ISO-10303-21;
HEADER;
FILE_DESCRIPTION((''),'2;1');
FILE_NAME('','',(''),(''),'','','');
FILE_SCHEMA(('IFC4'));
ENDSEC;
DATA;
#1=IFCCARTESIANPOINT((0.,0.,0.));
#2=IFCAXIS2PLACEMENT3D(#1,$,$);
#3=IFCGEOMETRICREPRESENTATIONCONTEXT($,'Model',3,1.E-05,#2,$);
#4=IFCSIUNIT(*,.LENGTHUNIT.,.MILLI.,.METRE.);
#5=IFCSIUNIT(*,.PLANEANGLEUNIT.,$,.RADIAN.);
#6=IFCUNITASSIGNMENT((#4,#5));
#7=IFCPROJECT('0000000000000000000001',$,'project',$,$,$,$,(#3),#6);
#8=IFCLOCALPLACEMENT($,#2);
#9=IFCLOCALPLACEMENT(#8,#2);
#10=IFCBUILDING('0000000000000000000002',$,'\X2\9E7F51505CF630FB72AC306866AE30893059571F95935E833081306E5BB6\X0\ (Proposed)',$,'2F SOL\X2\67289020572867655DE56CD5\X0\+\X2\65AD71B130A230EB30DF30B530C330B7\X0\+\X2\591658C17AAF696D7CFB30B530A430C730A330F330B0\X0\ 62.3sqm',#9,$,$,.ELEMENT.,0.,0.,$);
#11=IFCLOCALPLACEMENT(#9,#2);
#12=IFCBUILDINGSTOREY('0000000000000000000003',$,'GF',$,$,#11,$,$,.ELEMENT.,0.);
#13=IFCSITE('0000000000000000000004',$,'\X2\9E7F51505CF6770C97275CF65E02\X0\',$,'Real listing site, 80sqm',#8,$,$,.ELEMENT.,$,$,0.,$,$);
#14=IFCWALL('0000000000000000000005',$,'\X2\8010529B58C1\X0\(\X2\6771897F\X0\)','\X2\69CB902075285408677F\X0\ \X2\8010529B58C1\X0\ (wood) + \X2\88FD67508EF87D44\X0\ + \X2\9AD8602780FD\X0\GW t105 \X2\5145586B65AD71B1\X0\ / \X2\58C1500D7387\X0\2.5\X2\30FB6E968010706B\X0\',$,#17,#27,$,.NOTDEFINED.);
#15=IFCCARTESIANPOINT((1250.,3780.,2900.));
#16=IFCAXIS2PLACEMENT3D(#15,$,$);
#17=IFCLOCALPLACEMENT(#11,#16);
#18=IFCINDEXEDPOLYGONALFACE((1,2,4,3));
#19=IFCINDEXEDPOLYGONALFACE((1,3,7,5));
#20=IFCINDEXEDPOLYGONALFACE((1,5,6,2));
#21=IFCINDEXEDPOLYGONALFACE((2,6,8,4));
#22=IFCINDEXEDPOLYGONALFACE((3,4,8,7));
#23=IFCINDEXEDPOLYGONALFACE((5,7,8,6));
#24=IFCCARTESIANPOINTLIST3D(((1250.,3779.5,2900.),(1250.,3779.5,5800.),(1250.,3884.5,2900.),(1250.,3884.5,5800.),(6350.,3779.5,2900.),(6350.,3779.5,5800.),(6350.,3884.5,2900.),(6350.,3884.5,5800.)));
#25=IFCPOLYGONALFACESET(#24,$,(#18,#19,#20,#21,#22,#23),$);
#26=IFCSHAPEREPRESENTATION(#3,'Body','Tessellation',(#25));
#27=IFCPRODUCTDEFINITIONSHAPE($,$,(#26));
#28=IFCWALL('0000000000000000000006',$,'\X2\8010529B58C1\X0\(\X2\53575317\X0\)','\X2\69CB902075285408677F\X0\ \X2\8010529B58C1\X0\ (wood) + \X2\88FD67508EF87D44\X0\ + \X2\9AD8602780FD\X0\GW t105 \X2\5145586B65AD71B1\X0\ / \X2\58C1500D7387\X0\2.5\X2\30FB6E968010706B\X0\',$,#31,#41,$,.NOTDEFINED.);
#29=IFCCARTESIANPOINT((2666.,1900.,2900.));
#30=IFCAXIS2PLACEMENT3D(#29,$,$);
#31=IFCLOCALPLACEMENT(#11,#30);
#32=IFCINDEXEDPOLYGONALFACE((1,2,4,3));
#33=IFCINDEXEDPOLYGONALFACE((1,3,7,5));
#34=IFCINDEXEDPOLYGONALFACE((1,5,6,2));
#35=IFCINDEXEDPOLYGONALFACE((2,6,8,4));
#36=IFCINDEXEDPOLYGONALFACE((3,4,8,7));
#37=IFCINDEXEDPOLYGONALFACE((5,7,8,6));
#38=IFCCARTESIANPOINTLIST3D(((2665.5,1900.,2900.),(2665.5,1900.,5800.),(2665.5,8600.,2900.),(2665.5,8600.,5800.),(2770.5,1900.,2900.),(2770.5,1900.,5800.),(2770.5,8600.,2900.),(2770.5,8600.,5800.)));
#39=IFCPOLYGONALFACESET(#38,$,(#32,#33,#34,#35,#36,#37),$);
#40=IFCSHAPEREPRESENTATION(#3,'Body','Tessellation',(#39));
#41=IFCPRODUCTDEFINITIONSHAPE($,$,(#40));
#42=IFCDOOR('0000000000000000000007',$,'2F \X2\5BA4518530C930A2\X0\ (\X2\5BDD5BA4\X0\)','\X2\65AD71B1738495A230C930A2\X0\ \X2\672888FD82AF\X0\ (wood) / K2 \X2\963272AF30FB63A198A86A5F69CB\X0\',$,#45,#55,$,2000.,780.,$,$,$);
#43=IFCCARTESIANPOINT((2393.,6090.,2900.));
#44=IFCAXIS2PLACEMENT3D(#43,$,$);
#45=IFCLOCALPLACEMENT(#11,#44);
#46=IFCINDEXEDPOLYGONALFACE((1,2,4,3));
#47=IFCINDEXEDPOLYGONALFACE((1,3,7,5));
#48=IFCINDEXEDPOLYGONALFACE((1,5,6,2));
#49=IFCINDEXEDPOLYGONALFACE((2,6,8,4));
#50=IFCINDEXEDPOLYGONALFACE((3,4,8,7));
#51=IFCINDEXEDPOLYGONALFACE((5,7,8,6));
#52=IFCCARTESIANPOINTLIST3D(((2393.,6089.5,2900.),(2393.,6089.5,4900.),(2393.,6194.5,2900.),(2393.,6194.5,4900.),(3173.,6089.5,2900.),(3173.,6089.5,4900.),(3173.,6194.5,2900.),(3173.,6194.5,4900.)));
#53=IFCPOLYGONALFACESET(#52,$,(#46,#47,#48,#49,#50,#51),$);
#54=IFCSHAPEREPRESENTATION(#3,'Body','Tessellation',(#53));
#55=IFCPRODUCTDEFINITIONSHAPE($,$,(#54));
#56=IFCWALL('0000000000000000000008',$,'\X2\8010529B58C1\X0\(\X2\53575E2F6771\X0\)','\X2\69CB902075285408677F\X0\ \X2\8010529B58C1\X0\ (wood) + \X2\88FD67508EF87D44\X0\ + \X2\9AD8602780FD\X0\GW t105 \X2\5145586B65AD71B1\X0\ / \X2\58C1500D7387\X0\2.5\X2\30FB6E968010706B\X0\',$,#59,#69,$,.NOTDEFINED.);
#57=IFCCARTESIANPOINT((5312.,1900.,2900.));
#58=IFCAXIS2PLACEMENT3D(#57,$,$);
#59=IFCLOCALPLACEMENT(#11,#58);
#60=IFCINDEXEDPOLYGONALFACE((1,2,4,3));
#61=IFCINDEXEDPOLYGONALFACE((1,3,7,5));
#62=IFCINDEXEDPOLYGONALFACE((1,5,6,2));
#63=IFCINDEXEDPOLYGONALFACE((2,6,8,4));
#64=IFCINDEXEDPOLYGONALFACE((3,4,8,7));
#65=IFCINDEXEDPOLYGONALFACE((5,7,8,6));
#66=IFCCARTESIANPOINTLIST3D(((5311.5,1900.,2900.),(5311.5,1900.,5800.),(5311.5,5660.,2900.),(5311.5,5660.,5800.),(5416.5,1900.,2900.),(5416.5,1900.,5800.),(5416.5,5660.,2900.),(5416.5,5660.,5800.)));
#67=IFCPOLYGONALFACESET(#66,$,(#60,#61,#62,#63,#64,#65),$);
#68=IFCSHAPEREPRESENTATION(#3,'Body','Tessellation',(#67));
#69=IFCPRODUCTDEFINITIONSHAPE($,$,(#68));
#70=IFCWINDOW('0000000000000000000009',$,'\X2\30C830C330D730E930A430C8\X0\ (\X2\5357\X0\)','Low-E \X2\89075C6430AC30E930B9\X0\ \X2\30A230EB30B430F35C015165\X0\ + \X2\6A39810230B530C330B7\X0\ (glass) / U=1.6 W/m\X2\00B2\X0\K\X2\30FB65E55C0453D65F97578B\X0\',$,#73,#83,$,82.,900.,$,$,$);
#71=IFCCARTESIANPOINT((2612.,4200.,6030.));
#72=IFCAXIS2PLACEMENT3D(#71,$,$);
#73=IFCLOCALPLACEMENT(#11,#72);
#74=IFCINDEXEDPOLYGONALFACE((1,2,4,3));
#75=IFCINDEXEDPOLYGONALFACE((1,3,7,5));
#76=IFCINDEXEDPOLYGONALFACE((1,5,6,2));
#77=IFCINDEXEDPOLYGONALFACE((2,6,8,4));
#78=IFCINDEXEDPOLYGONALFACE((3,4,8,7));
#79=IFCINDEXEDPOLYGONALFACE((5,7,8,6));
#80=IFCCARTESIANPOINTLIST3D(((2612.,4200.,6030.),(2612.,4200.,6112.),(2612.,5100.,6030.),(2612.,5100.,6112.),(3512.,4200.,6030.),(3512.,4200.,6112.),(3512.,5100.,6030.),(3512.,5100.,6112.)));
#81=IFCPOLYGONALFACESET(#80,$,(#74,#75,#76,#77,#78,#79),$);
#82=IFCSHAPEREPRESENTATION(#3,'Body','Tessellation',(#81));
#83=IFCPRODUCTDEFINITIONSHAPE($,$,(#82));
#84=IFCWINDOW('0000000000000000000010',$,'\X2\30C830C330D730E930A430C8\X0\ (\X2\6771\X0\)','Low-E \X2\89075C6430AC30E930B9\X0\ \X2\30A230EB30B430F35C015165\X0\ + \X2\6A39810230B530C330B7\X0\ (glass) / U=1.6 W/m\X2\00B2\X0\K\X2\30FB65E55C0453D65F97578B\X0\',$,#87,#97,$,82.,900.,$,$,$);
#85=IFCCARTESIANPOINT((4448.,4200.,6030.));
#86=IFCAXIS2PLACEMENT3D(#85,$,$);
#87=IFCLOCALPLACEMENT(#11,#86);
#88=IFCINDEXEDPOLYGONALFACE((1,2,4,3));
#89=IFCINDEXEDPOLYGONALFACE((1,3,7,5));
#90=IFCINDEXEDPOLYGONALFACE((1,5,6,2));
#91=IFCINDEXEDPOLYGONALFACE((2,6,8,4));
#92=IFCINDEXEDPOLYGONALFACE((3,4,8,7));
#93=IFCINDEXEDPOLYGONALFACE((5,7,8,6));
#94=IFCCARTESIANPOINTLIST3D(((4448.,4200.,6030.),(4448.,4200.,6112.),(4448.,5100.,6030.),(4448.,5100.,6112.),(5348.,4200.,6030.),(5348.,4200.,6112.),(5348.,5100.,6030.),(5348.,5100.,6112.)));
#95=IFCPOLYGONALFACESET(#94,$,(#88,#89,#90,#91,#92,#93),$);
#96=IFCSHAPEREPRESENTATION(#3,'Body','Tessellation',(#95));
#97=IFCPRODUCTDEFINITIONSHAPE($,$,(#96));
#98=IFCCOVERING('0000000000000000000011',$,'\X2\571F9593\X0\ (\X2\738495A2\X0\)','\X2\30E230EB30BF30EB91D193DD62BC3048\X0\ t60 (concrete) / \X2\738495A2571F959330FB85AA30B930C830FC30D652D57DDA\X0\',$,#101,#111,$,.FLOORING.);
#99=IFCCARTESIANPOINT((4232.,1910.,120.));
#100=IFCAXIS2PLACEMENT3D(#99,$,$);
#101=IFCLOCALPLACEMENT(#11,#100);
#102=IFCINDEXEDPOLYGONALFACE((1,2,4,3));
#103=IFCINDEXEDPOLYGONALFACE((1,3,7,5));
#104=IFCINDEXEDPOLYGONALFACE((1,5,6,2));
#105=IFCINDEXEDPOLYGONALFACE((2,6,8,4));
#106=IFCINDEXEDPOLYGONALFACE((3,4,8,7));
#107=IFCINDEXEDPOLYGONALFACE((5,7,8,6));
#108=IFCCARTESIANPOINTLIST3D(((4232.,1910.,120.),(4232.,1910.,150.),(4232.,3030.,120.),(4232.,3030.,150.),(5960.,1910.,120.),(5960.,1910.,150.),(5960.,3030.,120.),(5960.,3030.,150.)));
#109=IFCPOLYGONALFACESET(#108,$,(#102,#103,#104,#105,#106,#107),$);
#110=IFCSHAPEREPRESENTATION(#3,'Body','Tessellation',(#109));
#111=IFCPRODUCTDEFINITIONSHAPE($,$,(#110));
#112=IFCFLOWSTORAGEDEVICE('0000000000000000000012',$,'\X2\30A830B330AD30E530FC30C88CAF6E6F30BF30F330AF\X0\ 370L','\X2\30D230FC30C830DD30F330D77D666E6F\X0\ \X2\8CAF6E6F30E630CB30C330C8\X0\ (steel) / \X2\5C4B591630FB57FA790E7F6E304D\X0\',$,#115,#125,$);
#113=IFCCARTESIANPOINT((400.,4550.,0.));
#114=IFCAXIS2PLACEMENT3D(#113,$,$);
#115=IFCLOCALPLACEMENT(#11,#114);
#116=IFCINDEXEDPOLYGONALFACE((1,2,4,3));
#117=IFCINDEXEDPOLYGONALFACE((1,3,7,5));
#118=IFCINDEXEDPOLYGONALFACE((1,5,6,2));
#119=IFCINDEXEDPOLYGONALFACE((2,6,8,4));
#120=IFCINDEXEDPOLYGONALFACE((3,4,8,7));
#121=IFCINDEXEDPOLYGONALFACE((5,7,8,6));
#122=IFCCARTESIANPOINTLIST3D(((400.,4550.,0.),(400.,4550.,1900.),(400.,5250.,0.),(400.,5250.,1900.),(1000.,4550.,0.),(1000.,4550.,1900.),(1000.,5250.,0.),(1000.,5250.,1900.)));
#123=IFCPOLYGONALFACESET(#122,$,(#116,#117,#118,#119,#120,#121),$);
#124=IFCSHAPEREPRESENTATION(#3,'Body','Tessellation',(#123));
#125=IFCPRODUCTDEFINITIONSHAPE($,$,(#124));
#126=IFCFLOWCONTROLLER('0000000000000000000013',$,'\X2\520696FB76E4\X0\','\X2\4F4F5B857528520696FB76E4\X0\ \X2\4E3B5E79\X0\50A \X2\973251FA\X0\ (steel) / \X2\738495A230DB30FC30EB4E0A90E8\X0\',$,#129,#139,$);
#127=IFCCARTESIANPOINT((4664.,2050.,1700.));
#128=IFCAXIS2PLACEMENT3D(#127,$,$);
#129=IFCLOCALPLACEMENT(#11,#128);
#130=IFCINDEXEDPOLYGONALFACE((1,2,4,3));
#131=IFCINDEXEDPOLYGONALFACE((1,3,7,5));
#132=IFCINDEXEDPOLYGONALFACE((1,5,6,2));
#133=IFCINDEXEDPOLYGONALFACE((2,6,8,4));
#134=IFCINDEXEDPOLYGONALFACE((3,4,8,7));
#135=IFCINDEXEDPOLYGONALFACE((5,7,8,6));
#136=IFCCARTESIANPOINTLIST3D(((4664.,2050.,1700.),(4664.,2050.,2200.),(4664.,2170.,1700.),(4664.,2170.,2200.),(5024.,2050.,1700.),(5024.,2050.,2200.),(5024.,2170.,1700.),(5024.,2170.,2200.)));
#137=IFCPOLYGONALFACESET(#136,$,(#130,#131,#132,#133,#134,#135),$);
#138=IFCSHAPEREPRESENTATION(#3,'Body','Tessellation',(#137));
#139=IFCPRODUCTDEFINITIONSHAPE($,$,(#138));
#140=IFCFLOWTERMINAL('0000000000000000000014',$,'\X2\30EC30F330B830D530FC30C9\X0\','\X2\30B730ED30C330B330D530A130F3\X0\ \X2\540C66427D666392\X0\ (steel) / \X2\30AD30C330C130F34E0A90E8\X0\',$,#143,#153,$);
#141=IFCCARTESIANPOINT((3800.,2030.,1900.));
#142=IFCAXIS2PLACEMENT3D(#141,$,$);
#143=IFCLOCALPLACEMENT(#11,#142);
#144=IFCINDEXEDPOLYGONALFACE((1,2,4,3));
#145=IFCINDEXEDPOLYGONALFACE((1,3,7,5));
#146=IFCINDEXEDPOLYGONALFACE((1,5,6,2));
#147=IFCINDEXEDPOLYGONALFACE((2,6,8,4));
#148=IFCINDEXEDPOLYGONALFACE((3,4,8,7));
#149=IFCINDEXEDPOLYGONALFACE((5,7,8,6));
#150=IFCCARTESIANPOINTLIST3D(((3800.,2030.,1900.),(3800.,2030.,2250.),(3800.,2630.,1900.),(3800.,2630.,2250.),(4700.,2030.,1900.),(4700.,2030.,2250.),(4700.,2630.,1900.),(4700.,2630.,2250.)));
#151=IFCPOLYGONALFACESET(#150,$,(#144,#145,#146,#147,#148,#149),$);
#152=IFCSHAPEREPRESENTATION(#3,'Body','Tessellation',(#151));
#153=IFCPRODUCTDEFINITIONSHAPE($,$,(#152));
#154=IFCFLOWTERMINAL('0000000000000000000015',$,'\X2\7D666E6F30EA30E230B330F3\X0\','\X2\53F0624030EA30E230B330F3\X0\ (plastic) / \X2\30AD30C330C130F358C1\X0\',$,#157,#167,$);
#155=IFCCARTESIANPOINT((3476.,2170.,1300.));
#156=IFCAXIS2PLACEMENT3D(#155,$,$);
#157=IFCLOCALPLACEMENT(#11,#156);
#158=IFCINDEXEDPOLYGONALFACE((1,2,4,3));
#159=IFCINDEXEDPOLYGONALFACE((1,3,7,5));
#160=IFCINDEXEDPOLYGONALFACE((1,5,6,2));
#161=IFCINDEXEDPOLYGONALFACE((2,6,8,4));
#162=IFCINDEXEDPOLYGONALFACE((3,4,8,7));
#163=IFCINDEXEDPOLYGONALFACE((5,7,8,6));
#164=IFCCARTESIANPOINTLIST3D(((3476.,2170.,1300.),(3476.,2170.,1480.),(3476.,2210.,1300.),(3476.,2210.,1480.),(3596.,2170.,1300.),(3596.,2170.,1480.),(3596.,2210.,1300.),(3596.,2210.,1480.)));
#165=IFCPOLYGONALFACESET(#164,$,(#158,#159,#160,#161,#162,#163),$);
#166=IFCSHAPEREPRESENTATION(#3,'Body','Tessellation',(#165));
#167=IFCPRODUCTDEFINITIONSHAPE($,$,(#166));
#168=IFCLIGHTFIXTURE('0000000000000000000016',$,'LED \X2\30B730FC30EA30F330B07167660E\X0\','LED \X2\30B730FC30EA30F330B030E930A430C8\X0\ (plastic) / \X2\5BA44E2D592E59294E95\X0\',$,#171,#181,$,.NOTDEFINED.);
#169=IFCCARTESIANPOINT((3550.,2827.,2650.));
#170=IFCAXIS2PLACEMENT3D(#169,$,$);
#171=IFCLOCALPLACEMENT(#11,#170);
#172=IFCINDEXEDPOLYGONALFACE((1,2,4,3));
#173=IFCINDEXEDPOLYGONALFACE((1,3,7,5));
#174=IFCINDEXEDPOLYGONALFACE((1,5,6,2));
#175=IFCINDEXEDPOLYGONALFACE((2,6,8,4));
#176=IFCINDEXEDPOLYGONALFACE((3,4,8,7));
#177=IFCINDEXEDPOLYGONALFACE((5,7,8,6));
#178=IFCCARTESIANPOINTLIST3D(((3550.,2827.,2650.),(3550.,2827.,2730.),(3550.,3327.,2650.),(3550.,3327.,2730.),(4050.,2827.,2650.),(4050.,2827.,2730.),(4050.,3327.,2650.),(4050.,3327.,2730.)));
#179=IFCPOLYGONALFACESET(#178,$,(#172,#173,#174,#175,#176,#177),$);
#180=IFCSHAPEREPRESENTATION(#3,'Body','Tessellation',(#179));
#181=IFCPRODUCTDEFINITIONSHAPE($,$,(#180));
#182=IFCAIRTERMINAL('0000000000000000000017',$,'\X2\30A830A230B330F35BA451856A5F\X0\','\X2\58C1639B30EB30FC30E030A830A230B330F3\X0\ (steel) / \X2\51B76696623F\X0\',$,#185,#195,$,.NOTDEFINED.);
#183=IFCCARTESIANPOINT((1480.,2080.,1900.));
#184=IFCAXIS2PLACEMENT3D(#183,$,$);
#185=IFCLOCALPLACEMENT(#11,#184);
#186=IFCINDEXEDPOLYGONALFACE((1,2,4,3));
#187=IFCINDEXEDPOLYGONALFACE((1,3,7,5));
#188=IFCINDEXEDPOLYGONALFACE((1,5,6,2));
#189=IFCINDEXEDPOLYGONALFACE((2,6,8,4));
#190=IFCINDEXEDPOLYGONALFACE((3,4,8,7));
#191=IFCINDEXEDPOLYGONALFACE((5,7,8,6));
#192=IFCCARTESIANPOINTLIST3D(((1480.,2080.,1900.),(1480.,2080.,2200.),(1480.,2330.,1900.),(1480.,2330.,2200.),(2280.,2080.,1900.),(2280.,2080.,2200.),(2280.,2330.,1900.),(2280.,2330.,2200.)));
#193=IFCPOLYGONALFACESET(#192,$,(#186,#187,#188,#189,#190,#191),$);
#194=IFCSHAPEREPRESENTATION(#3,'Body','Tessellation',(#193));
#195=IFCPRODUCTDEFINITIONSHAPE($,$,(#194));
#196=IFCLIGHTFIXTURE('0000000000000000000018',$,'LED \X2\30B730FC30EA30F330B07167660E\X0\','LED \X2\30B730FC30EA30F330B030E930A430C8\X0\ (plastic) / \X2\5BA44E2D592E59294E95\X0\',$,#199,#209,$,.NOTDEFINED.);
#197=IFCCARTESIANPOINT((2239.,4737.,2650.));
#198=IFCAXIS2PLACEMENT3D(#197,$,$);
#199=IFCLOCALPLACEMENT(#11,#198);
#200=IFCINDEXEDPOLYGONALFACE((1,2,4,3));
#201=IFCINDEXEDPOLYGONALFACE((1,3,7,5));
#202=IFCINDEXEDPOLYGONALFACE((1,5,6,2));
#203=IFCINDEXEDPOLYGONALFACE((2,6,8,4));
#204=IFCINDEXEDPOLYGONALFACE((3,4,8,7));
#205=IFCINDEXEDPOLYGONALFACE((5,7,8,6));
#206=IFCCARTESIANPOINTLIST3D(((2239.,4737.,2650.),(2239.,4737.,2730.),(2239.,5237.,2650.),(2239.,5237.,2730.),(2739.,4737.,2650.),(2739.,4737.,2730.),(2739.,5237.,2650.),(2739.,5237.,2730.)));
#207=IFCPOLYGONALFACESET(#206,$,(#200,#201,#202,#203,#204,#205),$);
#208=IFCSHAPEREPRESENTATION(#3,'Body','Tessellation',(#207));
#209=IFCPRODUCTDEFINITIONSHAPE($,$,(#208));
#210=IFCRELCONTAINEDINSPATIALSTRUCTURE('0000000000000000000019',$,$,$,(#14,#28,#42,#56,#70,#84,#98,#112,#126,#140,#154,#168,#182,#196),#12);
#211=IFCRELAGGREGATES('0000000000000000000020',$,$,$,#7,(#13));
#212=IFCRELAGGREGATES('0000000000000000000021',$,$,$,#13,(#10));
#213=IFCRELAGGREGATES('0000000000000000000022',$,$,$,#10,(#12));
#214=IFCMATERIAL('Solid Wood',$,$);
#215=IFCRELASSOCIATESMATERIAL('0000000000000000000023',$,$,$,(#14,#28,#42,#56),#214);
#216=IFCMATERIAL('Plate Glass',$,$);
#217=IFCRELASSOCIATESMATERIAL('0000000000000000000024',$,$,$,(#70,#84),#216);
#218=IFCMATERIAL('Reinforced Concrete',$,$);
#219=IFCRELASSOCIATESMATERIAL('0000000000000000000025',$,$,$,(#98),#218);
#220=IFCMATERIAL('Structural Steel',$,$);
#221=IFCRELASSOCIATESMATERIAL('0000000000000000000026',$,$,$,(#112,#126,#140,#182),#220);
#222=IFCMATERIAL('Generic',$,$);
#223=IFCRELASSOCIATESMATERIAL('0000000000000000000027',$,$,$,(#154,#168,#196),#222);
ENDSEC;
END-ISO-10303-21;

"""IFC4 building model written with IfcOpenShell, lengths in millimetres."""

from ifc_helpers import new_model, si_unit, frame, frame_2d, origin, place, context, project, spatial, rectangle, extrude, material, element, fill, save


model = new_model("IFC4")

# Units and contexts
model_context = context("Model", 3, precision=1e-05, world=origin())
ifc_project = project(units=[si_unit("LENGTHUNIT", "METRE", prefix="MILLI"), si_unit("PLANEANGLEUNIT", "RADIAN")], contexts=[model_context])

# Site, building, storey
site_placement = place(None, origin())
site = spatial("IfcSite", under=ifc_project, at=site_placement, Name="鹿児島県霧島市", ObjectType="Real listing site, 80sqm", CompositionType="ELEMENT", RefElevation=0.0)
building_placement = place(site_placement, origin())
building = spatial("IfcBuilding", under=site, at=building_placement, Name="鹿児島・犬と暮らす土間広めの家 (Proposed)", ObjectType="2F SOL木造在来工法+断熱アルミサッシ+外壁窯業系サイディング 62.3sqm", CompositionType="ELEMENT", ElevationOfRefHeight=0.0, ElevationOfTerrain=0.0)
storey_placement = place(building_placement, origin())
storey = spatial("IfcBuildingStorey", under=building, at=storey_placement, Name="GF", CompositionType="ELEMENT", Elevation=0.0)

# Shared definitions
ifc_material_1 = material(Name="Solid Wood")

# Wall
wall_1_placement = place(storey_placement, frame((1250.0, 3780.0, 2900.0)))
element("IfcWall", 1, at=wall_1_placement, inside=storey, material=ifc_material_1, Name="耐力壁(東西)", Description="構造用合板 耐力壁 (wood) + 製材軸組 + 高性能GW t105 充填断熱 / 壁倍率2.5・準耐火", PredefinedType="NOTDEFINED", context=model_context, shape_type="SweptSolid", body=[
    extrude(rectangle(XDim=5100.0, YDim=105.0, at=frame_2d((2550.0, 52.0))), frame((1250.0, 3780.0, 2900.0)), (0.0, 0.0, 1.0), 2900.0),
])

# Wall, opening, door
wall_2_placement = place(storey_placement, frame((2666.0, 1900.0, 2900.0)))
wall_2 = element("IfcWall", 2, at=wall_2_placement, inside=storey, material=ifc_material_1, Name="耐力壁(南北)", Description="構造用合板 耐力壁 (wood) + 製材軸組 + 高性能GW t105 充填断熱 / 壁倍率2.5・準耐火", PredefinedType="NOTDEFINED", context=model_context, shape_type="SweptSolid", body=[
    extrude(rectangle(XDim=105.0, YDim=6700.0, at=frame_2d((52.0, 3350.0))), frame((2666.0, 1900.0, 2900.0)), (0.0, 0.0, 1.0), 2900.0),
])
opening_placement = place(storey_placement, frame((2393.0, 6090.0, 2900.0)))
opening = element("IfcOpeningElement", 3, at=opening_placement, cuts=wall_2, PredefinedType="NOTDEFINED", context=model_context, shape_type="SweptSolid", body=[
    extrude(rectangle(XDim=780.0, YDim=105.0, at=frame_2d((390.0, 52.0))), frame((2393.0, 6090.0, 2900.0)), (0.0, 0.0, 1.0), 2000.0),
])
door_placement = place(storey_placement, frame((2393.0, 6090.0, 2900.0)))
door = element("IfcDoor", 4, at=door_placement, inside=storey, material=ifc_material_1, Name="2F 室内ドア (寝室)", Description="断熱玄関ドア 木製芯 (wood) / K2 防犯・採風機構", OverallHeight=2000.0, OverallWidth=780.0, context=model_context, shape_type="SweptSolid", body=[
    extrude(rectangle(XDim=780.0, YDim=105.0, at=frame_2d((390.0, 52.0))), frame((2393.0, 6090.0, 2900.0)), (0.0, 0.0, 1.0), 2000.0),
])
fill(opening, door)

# Wall
wall_3_placement = place(storey_placement, frame((5312.0, 1900.0, 2900.0)))
element("IfcWall", 5, at=wall_3_placement, inside=storey, material=ifc_material_1, Name="耐力壁(南帯東)", Description="構造用合板 耐力壁 (wood) + 製材軸組 + 高性能GW t105 充填断熱 / 壁倍率2.5・準耐火", PredefinedType="NOTDEFINED", context=model_context, shape_type="SweptSolid", body=[
    extrude(rectangle(XDim=105.0, YDim=3760.0, at=frame_2d((52.0, 1880.0))), frame((5312.0, 1900.0, 2900.0)), (0.0, 0.0, 1.0), 2900.0),
])

# Windows
ifc_material_2 = material(Name="Plate Glass")
window_1_placement = place(storey_placement, frame((2612.0, 4200.0, 6030.0)))
element("IfcWindow", 6, at=window_1_placement, inside=storey, material=ifc_material_2, Name="トップライト (南)", Description="Low-E 複層ガラス アルゴン封入 + 樹脂サッシ (glass) / U=1.6 W/m²K・日射取得型", OverallHeight=82.0, OverallWidth=900.0, context=model_context, shape_type="SweptSolid", body=[
    extrude(rectangle(XDim=900.0, YDim=900.0, at=frame_2d((450.0, 450.0))), frame((2612.0, 4200.0, 6030.0)), (0.0, 0.0, 1.0), 82.0),
])
window_2_placement = place(storey_placement, frame((4448.0, 4200.0, 6030.0)))
element("IfcWindow", 7, at=window_2_placement, inside=storey, material=ifc_material_2, Name="トップライト (東)", Description="Low-E 複層ガラス アルゴン封入 + 樹脂サッシ (glass) / U=1.6 W/m²K・日射取得型", OverallHeight=82.0, OverallWidth=900.0, context=model_context, shape_type="SweptSolid", body=[
    extrude(rectangle(XDim=900.0, YDim=900.0, at=frame_2d((450.0, 450.0))), frame((4448.0, 4200.0, 6030.0)), (0.0, 0.0, 1.0), 82.0),
])

# Covering
ifc_material_3 = material(Name="Reinforced Concrete")
covering_placement = place(storey_placement, frame((4232.0, 1910.0, 120.0)))
element("IfcCovering", 8, at=covering_placement, inside=storey, material=ifc_material_3, Name="土間 (玄関)", Description="モルタル金鏝押え t60 (concrete) / 玄関土間・薪ストーブ動線", PredefinedType="FLOORING", context=model_context, shape_type="SweptSolid", body=[
    extrude(rectangle(XDim=1728.0, YDim=1120.0, at=frame_2d((864.0, 560.0))), frame((4232.0, 1910.0, 120.0)), (0.0, 0.0, 1.0), 30.0),
])

# Flow storage device
ifc_material_4 = material(Name="Structural Steel")
flow_storage_device_placement = place(storey_placement, frame((400.0, 4550.0, 0.0)))
element("IfcFlowStorageDevice", 9, at=flow_storage_device_placement, inside=storey, material=ifc_material_4, Name="エコキュート貯湯タンク 370L", Description="ヒートポンプ給湯 貯湯ユニット (steel) / 屋外・基礎置き", context=model_context, shape_type="SweptSolid", body=[
    extrude(rectangle(XDim=600.0, YDim=700.0, at=frame_2d((300.0, 350.0))), frame((400.0, 4550.0, 0.0)), (0.0, 0.0, 1.0), 1900.0),
])

# Flow controller
flow_controller_placement = place(storey_placement, frame((4664.0, 2050.0, 1700.0)))
element("IfcFlowController", 10, at=flow_controller_placement, inside=storey, material=ifc_material_4, Name="分電盤", Description="住宅用分電盤 主幹50A 露出 (steel) / 玄関ホール上部", context=model_context, shape_type="SweptSolid", body=[
    extrude(rectangle(XDim=360.0, YDim=120.0, at=frame_2d((180.0, 60.0))), frame((4664.0, 2050.0, 1700.0)), (0.0, 0.0, 1.0), 500.0),
])

# Flow terminals
flow_terminal_1_placement = place(storey_placement, frame((3800.0, 2030.0, 1900.0)))
element("IfcFlowTerminal", 11, at=flow_terminal_1_placement, inside=storey, material=ifc_material_4, Name="レンジフード", Description="シロッコファン 同時給排 (steel) / キッチン上部", context=model_context, shape_type="SweptSolid", body=[
    extrude(rectangle(XDim=900.0, YDim=600.0, at=frame_2d((450.0, 300.0))), frame((3800.0, 2030.0, 1900.0)), (0.0, 0.0, 1.0), 350.0),
])
ifc_material_5 = material(Name="Generic")
flow_terminal_2_placement = place(storey_placement, frame((3476.0, 2170.0, 1300.0)))
element("IfcFlowTerminal", 12, at=flow_terminal_2_placement, inside=storey, material=ifc_material_5, Name="給湯リモコン", Description="台所リモコン (plastic) / キッチン壁", context=model_context, shape_type="SweptSolid", body=[
    extrude(rectangle(XDim=120.0, YDim=40.0, at=frame_2d((60.0, 20.0))), frame((3476.0, 2170.0, 1300.0)), (0.0, 0.0, 1.0), 180.0),
])

# Light fixture
light_fixture_1_placement = place(storey_placement, frame((3550.0, 2827.0, 2650.0)))
element("IfcLightFixture", 13, at=light_fixture_1_placement, inside=storey, material=ifc_material_5, Name="LED シーリング照明", Description="LED シーリングライト (plastic) / 室中央天井", PredefinedType="NOTDEFINED", context=model_context, shape_type="SweptSolid", body=[
    extrude(rectangle(XDim=500.0, YDim=500.0, at=frame_2d((250.0, 250.0))), frame((3550.0, 2827.0, 2650.0)), (0.0, 0.0, 1.0), 80.0),
])

# Air terminal
air_terminal_1_placement = place(storey_placement, frame((1480.0, 2080.0, 1900.0)))
element("IfcAirTerminal", 14, at=air_terminal_1_placement, inside=storey, material=ifc_material_4, Name="エアコン室内機", Description="壁掛ルームエアコン (steel) / 冷暖房", PredefinedType="NOTDEFINED", context=model_context, shape_type="SweptSolid", body=[
    extrude(rectangle(XDim=800.0, YDim=250.0, at=frame_2d((400.0, 125.0))), frame((1480.0, 2080.0, 1900.0)), (0.0, 0.0, 1.0), 300.0),
])

# Light fixture
light_fixture_2_placement = place(storey_placement, frame((2239.0, 4737.0, 2650.0)))
element("IfcLightFixture", 15, at=light_fixture_2_placement, inside=storey, material=ifc_material_5, Name="LED シーリング照明", Description="LED シーリングライト (plastic) / 室中央天井", PredefinedType="NOTDEFINED", context=model_context, shape_type="SweptSolid", body=[
    extrude(rectangle(XDim=500.0, YDim=500.0, at=frame_2d((250.0, 250.0))), frame((2239.0, 4737.0, 2650.0)), (0.0, 0.0, 1.0), 80.0),
])

save(model, "model.ifc")
